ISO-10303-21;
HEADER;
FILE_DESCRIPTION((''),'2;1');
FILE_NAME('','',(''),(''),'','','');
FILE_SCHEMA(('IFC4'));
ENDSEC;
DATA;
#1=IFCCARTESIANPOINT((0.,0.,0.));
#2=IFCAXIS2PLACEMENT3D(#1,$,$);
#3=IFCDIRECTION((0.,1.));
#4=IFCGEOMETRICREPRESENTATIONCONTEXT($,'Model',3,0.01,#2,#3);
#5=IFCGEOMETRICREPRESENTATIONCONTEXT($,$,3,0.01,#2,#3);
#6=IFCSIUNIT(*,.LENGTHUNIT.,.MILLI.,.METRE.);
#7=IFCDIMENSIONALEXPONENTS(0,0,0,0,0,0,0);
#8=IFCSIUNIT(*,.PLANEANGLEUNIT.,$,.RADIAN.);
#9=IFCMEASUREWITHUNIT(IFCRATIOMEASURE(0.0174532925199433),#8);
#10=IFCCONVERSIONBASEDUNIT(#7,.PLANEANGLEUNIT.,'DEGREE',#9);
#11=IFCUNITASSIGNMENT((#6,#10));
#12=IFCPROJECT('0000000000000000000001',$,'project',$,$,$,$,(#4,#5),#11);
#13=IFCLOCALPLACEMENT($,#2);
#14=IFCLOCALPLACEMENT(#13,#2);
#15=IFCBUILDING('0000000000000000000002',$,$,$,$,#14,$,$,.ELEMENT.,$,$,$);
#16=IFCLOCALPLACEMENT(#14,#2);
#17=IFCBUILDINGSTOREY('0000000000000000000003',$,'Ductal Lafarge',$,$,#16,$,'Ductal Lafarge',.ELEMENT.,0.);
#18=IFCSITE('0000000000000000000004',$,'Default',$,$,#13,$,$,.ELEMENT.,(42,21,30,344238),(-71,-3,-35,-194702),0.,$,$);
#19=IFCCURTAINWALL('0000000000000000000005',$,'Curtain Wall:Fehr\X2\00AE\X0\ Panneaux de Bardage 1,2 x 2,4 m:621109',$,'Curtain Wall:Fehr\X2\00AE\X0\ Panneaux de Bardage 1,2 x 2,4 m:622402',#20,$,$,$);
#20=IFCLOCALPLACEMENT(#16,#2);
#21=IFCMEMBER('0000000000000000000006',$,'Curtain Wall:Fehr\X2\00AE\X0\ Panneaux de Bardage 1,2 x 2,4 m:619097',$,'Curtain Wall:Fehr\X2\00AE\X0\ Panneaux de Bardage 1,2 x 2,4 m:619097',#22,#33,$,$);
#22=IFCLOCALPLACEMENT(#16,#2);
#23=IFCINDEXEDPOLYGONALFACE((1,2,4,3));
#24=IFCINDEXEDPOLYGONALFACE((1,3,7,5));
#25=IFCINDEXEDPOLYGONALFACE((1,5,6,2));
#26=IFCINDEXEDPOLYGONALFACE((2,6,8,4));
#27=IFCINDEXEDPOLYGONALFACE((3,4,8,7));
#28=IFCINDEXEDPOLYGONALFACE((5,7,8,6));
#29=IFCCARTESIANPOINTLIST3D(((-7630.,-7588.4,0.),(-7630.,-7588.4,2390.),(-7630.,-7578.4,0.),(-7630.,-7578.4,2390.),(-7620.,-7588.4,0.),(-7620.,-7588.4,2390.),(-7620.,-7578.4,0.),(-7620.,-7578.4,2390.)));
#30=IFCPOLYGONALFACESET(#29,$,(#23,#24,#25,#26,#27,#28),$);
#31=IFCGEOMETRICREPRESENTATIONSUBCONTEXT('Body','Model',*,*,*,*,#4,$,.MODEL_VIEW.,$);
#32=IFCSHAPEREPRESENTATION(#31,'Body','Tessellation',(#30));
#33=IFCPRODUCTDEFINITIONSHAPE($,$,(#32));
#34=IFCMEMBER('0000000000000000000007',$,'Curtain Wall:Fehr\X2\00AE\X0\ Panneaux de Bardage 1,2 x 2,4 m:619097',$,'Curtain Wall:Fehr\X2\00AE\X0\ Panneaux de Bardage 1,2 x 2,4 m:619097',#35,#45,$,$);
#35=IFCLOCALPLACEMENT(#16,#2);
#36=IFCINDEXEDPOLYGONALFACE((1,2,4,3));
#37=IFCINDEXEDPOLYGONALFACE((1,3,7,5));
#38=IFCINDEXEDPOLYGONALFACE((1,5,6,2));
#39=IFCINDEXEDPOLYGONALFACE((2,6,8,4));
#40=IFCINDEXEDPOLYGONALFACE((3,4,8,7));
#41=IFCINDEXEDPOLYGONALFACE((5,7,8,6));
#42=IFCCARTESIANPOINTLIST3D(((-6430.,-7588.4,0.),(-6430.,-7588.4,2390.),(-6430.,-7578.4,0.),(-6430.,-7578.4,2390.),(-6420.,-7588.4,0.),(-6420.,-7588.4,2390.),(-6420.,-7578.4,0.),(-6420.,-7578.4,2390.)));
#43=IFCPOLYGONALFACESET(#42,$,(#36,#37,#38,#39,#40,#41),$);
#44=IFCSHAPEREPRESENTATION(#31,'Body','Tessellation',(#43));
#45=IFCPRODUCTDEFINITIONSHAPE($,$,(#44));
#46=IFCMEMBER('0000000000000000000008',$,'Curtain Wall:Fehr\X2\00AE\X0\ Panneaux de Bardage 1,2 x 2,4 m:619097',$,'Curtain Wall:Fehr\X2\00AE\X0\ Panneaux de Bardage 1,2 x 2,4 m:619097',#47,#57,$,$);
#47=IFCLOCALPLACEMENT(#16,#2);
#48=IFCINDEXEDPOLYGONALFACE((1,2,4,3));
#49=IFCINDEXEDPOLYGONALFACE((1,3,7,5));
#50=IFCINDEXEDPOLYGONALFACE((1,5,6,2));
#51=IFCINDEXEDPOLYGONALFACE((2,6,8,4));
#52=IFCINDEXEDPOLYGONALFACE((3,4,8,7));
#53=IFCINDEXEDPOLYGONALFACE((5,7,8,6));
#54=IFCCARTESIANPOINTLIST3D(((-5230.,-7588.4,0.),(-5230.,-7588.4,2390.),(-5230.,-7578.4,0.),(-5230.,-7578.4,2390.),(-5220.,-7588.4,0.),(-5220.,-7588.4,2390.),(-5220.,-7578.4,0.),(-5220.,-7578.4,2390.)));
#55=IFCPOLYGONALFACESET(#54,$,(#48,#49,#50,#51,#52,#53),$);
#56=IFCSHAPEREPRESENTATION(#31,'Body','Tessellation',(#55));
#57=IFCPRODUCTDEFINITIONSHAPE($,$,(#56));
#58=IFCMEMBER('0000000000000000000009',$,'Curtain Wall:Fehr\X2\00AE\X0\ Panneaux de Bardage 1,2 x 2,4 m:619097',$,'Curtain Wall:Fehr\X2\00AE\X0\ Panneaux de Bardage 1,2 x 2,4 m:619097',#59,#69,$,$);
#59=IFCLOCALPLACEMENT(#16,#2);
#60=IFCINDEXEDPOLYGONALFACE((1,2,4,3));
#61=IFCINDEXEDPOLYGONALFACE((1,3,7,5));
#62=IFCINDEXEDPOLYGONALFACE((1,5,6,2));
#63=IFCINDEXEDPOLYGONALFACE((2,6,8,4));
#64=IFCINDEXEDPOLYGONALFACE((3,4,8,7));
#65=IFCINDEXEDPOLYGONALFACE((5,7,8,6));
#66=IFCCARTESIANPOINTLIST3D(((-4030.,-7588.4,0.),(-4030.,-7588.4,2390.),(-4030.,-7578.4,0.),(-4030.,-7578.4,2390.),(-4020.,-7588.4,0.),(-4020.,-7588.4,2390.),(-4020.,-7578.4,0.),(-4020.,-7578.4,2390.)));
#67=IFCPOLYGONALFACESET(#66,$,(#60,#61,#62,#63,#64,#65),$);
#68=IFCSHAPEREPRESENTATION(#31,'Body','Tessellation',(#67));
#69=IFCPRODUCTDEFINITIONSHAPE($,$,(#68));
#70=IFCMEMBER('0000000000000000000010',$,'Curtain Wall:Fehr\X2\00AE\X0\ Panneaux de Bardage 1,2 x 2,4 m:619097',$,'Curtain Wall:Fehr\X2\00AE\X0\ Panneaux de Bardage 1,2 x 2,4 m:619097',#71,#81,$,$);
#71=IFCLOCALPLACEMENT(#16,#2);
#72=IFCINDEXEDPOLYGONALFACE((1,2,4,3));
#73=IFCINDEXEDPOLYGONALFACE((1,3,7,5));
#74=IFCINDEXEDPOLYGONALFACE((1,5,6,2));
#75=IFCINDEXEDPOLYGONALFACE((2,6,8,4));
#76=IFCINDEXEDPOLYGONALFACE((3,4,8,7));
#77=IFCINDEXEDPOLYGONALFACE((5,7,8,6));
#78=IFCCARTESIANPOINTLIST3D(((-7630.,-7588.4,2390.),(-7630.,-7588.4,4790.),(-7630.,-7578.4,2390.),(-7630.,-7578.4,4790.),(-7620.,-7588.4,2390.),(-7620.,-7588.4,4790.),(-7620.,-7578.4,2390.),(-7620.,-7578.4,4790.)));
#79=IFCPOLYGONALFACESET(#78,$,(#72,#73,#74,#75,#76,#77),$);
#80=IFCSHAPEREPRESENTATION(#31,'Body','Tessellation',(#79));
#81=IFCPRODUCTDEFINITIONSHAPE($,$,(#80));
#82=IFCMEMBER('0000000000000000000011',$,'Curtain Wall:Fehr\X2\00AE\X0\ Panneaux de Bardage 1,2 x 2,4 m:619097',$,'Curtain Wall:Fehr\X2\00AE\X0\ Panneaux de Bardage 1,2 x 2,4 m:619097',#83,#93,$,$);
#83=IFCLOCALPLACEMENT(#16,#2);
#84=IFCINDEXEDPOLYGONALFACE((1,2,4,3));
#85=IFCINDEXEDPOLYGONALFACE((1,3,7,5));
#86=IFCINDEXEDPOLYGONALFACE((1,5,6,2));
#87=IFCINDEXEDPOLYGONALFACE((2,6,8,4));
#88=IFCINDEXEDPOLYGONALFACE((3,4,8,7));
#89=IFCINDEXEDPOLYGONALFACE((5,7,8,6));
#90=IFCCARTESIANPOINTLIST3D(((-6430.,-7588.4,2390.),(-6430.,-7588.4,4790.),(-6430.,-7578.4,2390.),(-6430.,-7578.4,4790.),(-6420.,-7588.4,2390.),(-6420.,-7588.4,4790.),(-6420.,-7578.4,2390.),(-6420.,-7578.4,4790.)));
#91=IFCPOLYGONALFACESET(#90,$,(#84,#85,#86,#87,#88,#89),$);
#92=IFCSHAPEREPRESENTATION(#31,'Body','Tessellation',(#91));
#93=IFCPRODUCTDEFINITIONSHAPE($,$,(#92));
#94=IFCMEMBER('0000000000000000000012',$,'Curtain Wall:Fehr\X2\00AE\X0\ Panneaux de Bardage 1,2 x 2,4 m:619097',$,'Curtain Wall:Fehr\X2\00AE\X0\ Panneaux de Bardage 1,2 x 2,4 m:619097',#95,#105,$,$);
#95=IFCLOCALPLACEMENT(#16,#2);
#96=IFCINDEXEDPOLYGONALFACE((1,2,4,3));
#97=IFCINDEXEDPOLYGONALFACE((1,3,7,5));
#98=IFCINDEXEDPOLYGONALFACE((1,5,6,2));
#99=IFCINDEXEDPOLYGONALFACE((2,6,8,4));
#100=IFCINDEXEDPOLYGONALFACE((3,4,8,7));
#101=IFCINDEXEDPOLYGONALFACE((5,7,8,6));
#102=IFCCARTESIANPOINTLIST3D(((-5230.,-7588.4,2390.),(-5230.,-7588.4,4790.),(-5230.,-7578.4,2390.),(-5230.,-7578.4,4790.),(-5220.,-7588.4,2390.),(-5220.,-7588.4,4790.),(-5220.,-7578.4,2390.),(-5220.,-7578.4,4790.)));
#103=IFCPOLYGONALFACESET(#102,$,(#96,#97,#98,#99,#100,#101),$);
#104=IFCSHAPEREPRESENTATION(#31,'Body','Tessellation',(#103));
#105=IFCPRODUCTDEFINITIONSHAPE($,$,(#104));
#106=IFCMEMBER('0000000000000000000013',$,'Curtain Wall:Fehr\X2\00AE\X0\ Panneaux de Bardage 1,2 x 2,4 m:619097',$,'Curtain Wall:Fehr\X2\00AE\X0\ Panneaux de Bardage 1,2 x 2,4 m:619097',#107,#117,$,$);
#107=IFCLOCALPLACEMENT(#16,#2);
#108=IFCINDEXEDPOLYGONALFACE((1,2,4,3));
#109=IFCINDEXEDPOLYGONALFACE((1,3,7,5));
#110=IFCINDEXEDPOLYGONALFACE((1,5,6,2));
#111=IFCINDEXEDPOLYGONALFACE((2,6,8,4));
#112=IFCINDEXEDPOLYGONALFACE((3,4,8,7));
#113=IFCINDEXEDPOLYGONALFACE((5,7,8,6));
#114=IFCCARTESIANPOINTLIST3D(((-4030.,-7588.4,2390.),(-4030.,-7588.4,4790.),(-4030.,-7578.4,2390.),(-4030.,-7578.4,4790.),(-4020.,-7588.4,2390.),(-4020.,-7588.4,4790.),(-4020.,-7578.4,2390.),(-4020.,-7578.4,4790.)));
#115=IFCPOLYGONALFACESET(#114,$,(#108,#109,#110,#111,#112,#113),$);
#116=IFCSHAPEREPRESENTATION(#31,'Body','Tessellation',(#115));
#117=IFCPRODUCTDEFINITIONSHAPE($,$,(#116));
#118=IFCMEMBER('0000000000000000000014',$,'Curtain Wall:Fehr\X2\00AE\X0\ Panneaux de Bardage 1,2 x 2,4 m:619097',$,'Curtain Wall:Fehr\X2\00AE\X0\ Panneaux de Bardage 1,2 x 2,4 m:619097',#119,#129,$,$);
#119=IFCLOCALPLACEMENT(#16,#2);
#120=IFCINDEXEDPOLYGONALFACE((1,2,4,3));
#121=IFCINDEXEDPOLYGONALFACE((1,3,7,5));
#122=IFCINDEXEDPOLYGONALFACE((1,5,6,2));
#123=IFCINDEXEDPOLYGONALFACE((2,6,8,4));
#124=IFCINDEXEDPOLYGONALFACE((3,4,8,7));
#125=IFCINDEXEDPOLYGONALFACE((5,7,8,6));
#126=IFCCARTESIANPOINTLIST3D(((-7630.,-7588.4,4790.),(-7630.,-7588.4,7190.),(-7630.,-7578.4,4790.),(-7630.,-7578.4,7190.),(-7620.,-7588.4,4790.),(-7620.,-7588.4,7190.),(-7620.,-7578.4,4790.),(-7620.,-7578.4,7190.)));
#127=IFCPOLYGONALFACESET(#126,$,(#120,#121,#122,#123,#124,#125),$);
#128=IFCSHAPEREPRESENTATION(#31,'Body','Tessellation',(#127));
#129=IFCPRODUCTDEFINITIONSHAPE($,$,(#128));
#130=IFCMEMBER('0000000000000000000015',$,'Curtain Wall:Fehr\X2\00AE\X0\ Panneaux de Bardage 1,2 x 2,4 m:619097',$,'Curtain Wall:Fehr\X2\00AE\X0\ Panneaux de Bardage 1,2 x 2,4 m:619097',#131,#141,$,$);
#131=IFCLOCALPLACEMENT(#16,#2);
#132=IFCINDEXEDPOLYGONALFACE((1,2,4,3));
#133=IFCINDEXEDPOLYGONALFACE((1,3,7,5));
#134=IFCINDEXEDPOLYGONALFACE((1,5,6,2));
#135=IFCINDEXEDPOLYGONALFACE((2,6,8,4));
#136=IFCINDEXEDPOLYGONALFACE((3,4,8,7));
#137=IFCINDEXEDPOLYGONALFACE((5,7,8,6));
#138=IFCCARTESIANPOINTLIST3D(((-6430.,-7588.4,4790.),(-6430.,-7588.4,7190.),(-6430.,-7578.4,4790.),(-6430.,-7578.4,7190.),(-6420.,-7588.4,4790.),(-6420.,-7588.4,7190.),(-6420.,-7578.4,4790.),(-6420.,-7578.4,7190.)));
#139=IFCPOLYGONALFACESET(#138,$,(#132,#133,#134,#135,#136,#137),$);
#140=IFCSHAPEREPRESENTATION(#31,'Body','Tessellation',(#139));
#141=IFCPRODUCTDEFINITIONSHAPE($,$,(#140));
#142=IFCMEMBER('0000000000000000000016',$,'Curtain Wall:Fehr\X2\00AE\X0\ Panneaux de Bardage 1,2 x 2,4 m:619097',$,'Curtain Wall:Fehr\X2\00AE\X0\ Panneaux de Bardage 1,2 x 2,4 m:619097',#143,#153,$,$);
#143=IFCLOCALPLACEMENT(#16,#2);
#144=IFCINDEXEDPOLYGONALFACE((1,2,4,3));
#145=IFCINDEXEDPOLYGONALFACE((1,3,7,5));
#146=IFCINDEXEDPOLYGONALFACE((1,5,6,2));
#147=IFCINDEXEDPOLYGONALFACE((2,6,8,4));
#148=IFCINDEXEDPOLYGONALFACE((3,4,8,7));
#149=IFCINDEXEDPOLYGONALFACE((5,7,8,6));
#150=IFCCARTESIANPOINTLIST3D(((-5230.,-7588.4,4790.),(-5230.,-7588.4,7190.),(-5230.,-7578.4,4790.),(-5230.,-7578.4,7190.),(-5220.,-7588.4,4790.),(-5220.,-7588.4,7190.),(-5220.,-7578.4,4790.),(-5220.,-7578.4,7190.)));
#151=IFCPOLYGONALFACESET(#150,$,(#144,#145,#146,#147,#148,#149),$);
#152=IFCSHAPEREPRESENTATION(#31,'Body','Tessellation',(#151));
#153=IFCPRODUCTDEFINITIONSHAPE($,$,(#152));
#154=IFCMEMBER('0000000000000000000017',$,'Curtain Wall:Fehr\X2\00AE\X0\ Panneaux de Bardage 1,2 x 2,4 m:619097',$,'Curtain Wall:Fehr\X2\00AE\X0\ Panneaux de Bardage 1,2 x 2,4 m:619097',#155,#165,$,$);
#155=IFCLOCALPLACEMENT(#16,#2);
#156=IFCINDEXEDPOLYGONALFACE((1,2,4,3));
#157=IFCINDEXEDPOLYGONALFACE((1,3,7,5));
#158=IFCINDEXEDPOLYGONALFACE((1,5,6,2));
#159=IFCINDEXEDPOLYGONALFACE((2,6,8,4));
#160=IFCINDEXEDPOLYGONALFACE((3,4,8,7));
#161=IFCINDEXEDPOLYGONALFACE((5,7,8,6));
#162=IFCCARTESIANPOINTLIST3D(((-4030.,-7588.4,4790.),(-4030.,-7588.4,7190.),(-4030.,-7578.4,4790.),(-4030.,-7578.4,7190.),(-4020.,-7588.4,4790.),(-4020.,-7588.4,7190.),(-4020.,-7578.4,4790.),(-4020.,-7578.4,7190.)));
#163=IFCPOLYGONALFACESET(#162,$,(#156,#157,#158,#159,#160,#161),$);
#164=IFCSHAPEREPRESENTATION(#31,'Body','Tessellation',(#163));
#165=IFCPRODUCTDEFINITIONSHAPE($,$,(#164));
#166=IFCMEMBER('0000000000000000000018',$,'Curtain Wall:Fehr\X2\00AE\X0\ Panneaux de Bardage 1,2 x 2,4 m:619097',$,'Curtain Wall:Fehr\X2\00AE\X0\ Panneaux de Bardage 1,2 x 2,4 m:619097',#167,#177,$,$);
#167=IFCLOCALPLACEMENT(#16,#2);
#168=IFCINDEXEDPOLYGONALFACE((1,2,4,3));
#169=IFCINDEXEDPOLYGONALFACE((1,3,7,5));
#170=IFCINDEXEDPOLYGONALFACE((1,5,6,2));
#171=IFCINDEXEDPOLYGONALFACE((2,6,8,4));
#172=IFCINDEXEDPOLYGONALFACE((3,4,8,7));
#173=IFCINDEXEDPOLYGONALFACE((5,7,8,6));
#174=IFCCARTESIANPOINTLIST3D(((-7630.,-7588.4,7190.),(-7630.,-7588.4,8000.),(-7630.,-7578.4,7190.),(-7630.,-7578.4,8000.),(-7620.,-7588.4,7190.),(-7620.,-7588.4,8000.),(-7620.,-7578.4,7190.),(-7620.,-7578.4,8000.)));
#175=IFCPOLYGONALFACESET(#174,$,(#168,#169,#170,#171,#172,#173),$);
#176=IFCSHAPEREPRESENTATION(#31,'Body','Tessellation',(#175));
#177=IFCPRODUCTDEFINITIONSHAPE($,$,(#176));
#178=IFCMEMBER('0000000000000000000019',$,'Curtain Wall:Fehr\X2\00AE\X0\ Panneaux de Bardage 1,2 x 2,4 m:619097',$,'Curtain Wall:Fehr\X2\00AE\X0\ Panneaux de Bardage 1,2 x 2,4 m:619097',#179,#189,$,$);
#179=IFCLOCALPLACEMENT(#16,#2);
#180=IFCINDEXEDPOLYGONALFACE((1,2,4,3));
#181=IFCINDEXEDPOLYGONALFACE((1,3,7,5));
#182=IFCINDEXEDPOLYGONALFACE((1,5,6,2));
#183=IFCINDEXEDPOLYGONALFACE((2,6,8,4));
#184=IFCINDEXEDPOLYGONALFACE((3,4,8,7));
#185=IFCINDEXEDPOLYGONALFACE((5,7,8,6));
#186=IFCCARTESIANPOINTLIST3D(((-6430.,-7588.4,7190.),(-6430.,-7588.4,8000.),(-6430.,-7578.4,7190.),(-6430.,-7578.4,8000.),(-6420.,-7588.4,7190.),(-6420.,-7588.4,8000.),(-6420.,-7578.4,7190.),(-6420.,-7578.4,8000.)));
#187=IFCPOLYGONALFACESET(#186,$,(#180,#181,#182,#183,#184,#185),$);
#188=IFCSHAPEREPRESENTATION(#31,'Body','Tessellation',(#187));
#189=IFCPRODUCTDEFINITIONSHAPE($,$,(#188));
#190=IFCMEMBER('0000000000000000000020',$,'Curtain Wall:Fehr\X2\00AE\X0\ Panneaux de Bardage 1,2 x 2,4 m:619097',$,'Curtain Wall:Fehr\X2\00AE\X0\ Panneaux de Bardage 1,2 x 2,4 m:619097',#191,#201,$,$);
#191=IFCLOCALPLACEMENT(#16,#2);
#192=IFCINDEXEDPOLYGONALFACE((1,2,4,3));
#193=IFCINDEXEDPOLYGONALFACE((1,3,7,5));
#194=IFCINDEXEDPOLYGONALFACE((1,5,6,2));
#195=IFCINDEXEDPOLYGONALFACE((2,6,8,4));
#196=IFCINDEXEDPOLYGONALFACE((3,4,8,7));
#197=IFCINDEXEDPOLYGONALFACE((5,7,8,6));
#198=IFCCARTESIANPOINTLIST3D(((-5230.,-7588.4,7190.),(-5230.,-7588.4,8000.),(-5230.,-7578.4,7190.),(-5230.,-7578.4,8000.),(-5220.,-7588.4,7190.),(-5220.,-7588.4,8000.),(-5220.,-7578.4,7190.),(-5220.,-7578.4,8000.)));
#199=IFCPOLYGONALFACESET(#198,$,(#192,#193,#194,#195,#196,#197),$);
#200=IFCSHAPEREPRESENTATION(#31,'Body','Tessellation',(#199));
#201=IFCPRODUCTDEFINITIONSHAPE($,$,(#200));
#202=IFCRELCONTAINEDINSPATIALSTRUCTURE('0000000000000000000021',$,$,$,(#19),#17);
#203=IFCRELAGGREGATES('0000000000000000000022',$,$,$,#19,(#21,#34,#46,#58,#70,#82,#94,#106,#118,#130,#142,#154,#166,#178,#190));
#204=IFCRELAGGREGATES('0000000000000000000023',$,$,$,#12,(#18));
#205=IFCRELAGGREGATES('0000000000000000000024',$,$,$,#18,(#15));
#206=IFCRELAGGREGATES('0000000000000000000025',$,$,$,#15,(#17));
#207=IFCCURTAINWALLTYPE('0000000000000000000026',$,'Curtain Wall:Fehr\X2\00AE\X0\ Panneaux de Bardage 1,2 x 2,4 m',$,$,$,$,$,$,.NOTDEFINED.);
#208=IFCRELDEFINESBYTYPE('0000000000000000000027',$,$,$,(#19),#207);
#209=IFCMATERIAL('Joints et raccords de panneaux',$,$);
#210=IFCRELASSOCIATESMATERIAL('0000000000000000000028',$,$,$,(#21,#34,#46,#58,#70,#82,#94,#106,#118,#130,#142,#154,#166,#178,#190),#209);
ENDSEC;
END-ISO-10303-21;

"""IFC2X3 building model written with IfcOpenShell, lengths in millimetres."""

from ifc_helpers import new_model, entity, si_unit, converted_unit, direction, frame, frame_2d, origin, origin_2d_with_axis, place, context, subcontext, project, spatial, rectangle, extrude, material, type_object, element, aggregate, save


model = new_model("IFC2X3")

# Units and contexts
model_context = context("Model", 3, precision=0.01, world=origin(), true_north=direction((0.0, 1.0)))
context_of_model = context(None, 3, precision=0.01, world=origin(), true_north=direction((0.0, 1.0)))
body_context = subcontext(model_context, "Body", "Model", "MODEL_VIEW")
ifc_project = project(units=[si_unit("LENGTHUNIT", "METRE", prefix="MILLI"), converted_unit("PLANEANGLEUNIT", "DEGREE", entity("IfcRatioMeasure", 0.0174532925199433), si_unit("PLANEANGLEUNIT", "RADIAN"), dimensions=[0, 0, 0, 0, 0, 0, 0])], contexts=[model_context, context_of_model])

# Site, building, storey
site_placement = place(None, origin())
site = spatial("IfcSite", under=ifc_project, at=site_placement, Name="Default", CompositionType="ELEMENT", RefLatitude=(42, 21, 30, 344238), RefLongitude=(-71, -3, -35, -194702), RefElevation=0.0)
building_placement = place(site_placement, origin())
building = spatial("IfcBuilding", under=site, at=building_placement, CompositionType="ELEMENT")
storey_placement = place(building_placement, origin())
storey = spatial("IfcBuildingStorey", under=building, at=storey_placement, Name="Ductal Lafarge", LongName="Ductal Lafarge", CompositionType="ELEMENT", Elevation=0.0)

# Curtain wall, members
curtain_wall_type = type_object("IfcCurtainWallType", Name="Curtain Wall:Fehr® Panneaux de Bardage 1,2 x 2,4 m", PredefinedType="NOTDEFINED")
curtain_wall_placement = place(storey_placement, origin())
curtain_wall = element("IfcCurtainWall", 1, at=curtain_wall_placement, inside=storey, type_object=curtain_wall_type, Name="Curtain Wall:Fehr® Panneaux de Bardage 1,2 x 2,4 m:621109", ObjectType="Curtain Wall:Fehr® Panneaux de Bardage 1,2 x 2,4 m:622402")
ifc_material = material(Name="Joints et raccords de panneaux")
member_1_placement = place(curtain_wall_placement, frame((-7630.0, -7588.4, 0.0)))
member_1 = element("IfcMember", 2, at=member_1_placement, material=ifc_material, Name="Curtain Wall:Fehr® Panneaux de Bardage 1,2 x 2,4 m:619097", ObjectType="Curtain Wall:Fehr® Panneaux de Bardage 1,2 x 2,4 m:619097", context=body_context, shape_type="SweptSolid", body=[
    extrude(rectangle(XDim=10.0, YDim=10.0, at=frame_2d((0.0, 0.0), x_axis=(1.0, 0.0))), frame((5.0, 5.0, 0.0), z_axis=(0.0, 0.0, 1.0), x_axis=(0.0, 1.0, 0.0)), (0.0, 0.0, 1.0), 2390.0),
])
member_2_placement = place(curtain_wall_placement, frame((-6430.0, -7588.4, 0.0)))
member_2 = element("IfcMember", 3, at=member_2_placement, material=ifc_material, Name="Curtain Wall:Fehr® Panneaux de Bardage 1,2 x 2,4 m:619097", ObjectType="Curtain Wall:Fehr® Panneaux de Bardage 1,2 x 2,4 m:619097", context=body_context, shape_type="SweptSolid", body=[
    extrude(rectangle(XDim=10.0, YDim=10.0, at=frame_2d((0.0, 0.0), x_axis=(1.0, 0.0))), frame((5.0, 5.0, 0.0), z_axis=(0.0, 0.0, 1.0), x_axis=(0.0, 1.0, 0.0)), (0.0, 0.0, 1.0), 2390.0),
])
member_3_placement = place(curtain_wall_placement, frame((-5230.0, -7588.4, 0.0)))
member_3 = element("IfcMember", 4, at=member_3_placement, material=ifc_material, Name="Curtain Wall:Fehr® Panneaux de Bardage 1,2 x 2,4 m:619097", ObjectType="Curtain Wall:Fehr® Panneaux de Bardage 1,2 x 2,4 m:619097", context=body_context, shape_type="SweptSolid", body=[
    extrude(rectangle(XDim=10.0, YDim=10.0, at=frame_2d((0.0, 0.0), x_axis=(1.0, 0.0))), frame((5.0, 5.0, 0.0), z_axis=(0.0, 0.0, 1.0), x_axis=(0.0, 1.0, 0.0)), (0.0, 0.0, 1.0), 2390.0),
])
member_4_placement = place(curtain_wall_placement, frame((-4030.0, -7588.4, 0.0)))
member_4 = element("IfcMember", 5, at=member_4_placement, material=ifc_material, Name="Curtain Wall:Fehr® Panneaux de Bardage 1,2 x 2,4 m:619097", ObjectType="Curtain Wall:Fehr® Panneaux de Bardage 1,2 x 2,4 m:619097", context=body_context, shape_type="SweptSolid", body=[
    extrude(rectangle(XDim=10.0, YDim=10.0, at=origin_2d_with_axis()), frame((5.0, 5.0, 0.0), z_axis=(0.0, 0.0, 1.0), x_axis=(0.0, 1.0, 0.0)), (0.0, 0.0, 1.0), 2390.0),
])
member_5_placement = place(curtain_wall_placement, frame((-7630.0, -7588.4, 2390.0)))
member_5 = element("IfcMember", 6, at=member_5_placement, material=ifc_material, Name="Curtain Wall:Fehr® Panneaux de Bardage 1,2 x 2,4 m:619097", ObjectType="Curtain Wall:Fehr® Panneaux de Bardage 1,2 x 2,4 m:619097", context=body_context, shape_type="SweptSolid", body=[
    extrude(rectangle(XDim=10.0, YDim=10.0, at=frame_2d((0.0, 0.0), x_axis=(1.0, 0.0))), frame((5.0, 5.0, 0.0), z_axis=(0.0, 0.0, 1.0), x_axis=(0.0, 1.0, 0.0)), (0.0, 0.0, 1.0), 2400.0),
])
member_6_placement = place(curtain_wall_placement, frame((-6430.0, -7588.4, 2390.0)))
member_6 = element("IfcMember", 7, at=member_6_placement, material=ifc_material, Name="Curtain Wall:Fehr® Panneaux de Bardage 1,2 x 2,4 m:619097", ObjectType="Curtain Wall:Fehr® Panneaux de Bardage 1,2 x 2,4 m:619097", context=body_context, shape_type="SweptSolid", body=[
    extrude(rectangle(XDim=10.0, YDim=10.0, at=frame_2d((0.0, 0.0), x_axis=(1.0, 0.0))), frame((5.0, 5.0, 0.0), z_axis=(0.0, 0.0, 1.0), x_axis=(0.0, 1.0, 0.0)), (0.0, 0.0, 1.0), 2400.0),
])
member_7_placement = place(curtain_wall_placement, frame((-5230.0, -7588.4, 2390.0)))
member_7 = element("IfcMember", 8, at=member_7_placement, material=ifc_material, Name="Curtain Wall:Fehr® Panneaux de Bardage 1,2 x 2,4 m:619097", ObjectType="Curtain Wall:Fehr® Panneaux de Bardage 1,2 x 2,4 m:619097", context=body_context, shape_type="SweptSolid", body=[
    extrude(rectangle(XDim=10.0, YDim=10.0, at=frame_2d((0.0, 0.0), x_axis=(1.0, 0.0))), frame((5.0, 5.0, 0.0), z_axis=(0.0, 0.0, 1.0), x_axis=(0.0, 1.0, 0.0)), (0.0, 0.0, 1.0), 2400.0),
])
member_8_placement = place(curtain_wall_placement, frame((-4030.0, -7588.4, 2390.0)))
member_8 = element("IfcMember", 9, at=member_8_placement, material=ifc_material, Name="Curtain Wall:Fehr® Panneaux de Bardage 1,2 x 2,4 m:619097", ObjectType="Curtain Wall:Fehr® Panneaux de Bardage 1,2 x 2,4 m:619097", context=body_context, shape_type="SweptSolid", body=[
    extrude(rectangle(XDim=10.0, YDim=10.0, at=origin_2d_with_axis()), frame((5.0, 5.0, 0.0), z_axis=(0.0, 0.0, 1.0), x_axis=(0.0, 1.0, 0.0)), (0.0, 0.0, 1.0), 2400.0),
])
member_9_placement = place(curtain_wall_placement, frame((-7630.0, -7588.4, 4790.0)))
member_9 = element("IfcMember", 10, at=member_9_placement, material=ifc_material, Name="Curtain Wall:Fehr® Panneaux de Bardage 1,2 x 2,4 m:619097", ObjectType="Curtain Wall:Fehr® Panneaux de Bardage 1,2 x 2,4 m:619097", context=body_context, shape_type="SweptSolid", body=[
    extrude(rectangle(XDim=10.0, YDim=10.0, at=frame_2d((0.0, 0.0), x_axis=(1.0, 0.0))), frame((5.0, 5.0, 0.0), z_axis=(0.0, 0.0, 1.0), x_axis=(0.0, 1.0, 0.0)), (0.0, 0.0, 1.0), 2400.0),
])
member_10_placement = place(curtain_wall_placement, frame((-6430.0, -7588.4, 4790.0)))
member_10 = element("IfcMember", 11, at=member_10_placement, material=ifc_material, Name="Curtain Wall:Fehr® Panneaux de Bardage 1,2 x 2,4 m:619097", ObjectType="Curtain Wall:Fehr® Panneaux de Bardage 1,2 x 2,4 m:619097", context=body_context, shape_type="SweptSolid", body=[
    extrude(rectangle(XDim=10.0, YDim=10.0, at=frame_2d((0.0, 0.0), x_axis=(1.0, 0.0))), frame((5.0, 5.0, 0.0), z_axis=(0.0, 0.0, 1.0), x_axis=(0.0, 1.0, 0.0)), (0.0, 0.0, 1.0), 2400.0),
])
member_11_placement = place(curtain_wall_placement, frame((-5230.0, -7588.4, 4790.0)))
member_11 = element("IfcMember", 12, at=member_11_placement, material=ifc_material, Name="Curtain Wall:Fehr® Panneaux de Bardage 1,2 x 2,4 m:619097", ObjectType="Curtain Wall:Fehr® Panneaux de Bardage 1,2 x 2,4 m:619097", context=body_context, shape_type="SweptSolid", body=[
    extrude(rectangle(XDim=10.0, YDim=10.0, at=frame_2d((0.0, 0.0), x_axis=(1.0, 0.0))), frame((5.0, 5.0, 0.0), z_axis=(0.0, 0.0, 1.0), x_axis=(0.0, 1.0, 0.0)), (0.0, 0.0, 1.0), 2400.0),
])
member_12_placement = place(curtain_wall_placement, frame((-4030.0, -7588.4, 4790.0)))
member_12 = element("IfcMember", 13, at=member_12_placement, material=ifc_material, Name="Curtain Wall:Fehr® Panneaux de Bardage 1,2 x 2,4 m:619097", ObjectType="Curtain Wall:Fehr® Panneaux de Bardage 1,2 x 2,4 m:619097", context=body_context, shape_type="SweptSolid", body=[
    extrude(rectangle(XDim=10.0, YDim=10.0, at=origin_2d_with_axis()), frame((5.0, 5.0, 0.0), z_axis=(0.0, 0.0, 1.0), x_axis=(0.0, 1.0, 0.0)), (0.0, 0.0, 1.0), 2400.0),
])
member_13_placement = place(curtain_wall_placement, frame((-7630.0, -7588.4, 7190.0)))
member_13 = element("IfcMember", 14, at=member_13_placement, material=ifc_material, Name="Curtain Wall:Fehr® Panneaux de Bardage 1,2 x 2,4 m:619097", ObjectType="Curtain Wall:Fehr® Panneaux de Bardage 1,2 x 2,4 m:619097", context=body_context, shape_type="SweptSolid", body=[
    extrude(rectangle(XDim=10.0, YDim=10.0, at=frame_2d((0.0, 0.0), x_axis=(1.0, 0.0))), frame((5.0, 5.0, 0.0), z_axis=(0.0, 0.0, 1.0), x_axis=(0.0, 1.0, 0.0)), (0.0, 0.0, 1.0), 810.0),
])
member_14_placement = place(curtain_wall_placement, frame((-6430.0, -7588.4, 7190.0)))
member_14 = element("IfcMember", 15, at=member_14_placement, material=ifc_material, Name="Curtain Wall:Fehr® Panneaux de Bardage 1,2 x 2,4 m:619097", ObjectType="Curtain Wall:Fehr® Panneaux de Bardage 1,2 x 2,4 m:619097", context=body_context, shape_type="SweptSolid", body=[
    extrude(rectangle(XDim=10.0, YDim=10.0, at=frame_2d((0.0, 0.0), x_axis=(1.0, 0.0))), frame((5.0, 5.0, 0.0), z_axis=(0.0, 0.0, 1.0), x_axis=(0.0, 1.0, 0.0)), (0.0, 0.0, 1.0), 810.0),
])
member_15_placement = place(curtain_wall_placement, frame((-5230.0, -7588.4, 7190.0)))
member_15 = element("IfcMember", 16, at=member_15_placement, material=ifc_material, Name="Curtain Wall:Fehr® Panneaux de Bardage 1,2 x 2,4 m:619097", ObjectType="Curtain Wall:Fehr® Panneaux de Bardage 1,2 x 2,4 m:619097", context=body_context, shape_type="SweptSolid", body=[
    extrude(rectangle(XDim=10.0, YDim=10.0, at=frame_2d((0.0, 0.0), x_axis=(1.0, 0.0))), frame((5.0, 5.0, 0.0), z_axis=(0.0, 0.0, 1.0), x_axis=(0.0, 1.0, 0.0)), (0.0, 0.0, 1.0), 810.0),
])
aggregate(curtain_wall, [member_1, member_2, member_3, member_4, member_5, member_6, member_7, member_8, member_9, member_10, member_11, member_12, member_13, member_14, member_15])

save(model, "model.ifc")
